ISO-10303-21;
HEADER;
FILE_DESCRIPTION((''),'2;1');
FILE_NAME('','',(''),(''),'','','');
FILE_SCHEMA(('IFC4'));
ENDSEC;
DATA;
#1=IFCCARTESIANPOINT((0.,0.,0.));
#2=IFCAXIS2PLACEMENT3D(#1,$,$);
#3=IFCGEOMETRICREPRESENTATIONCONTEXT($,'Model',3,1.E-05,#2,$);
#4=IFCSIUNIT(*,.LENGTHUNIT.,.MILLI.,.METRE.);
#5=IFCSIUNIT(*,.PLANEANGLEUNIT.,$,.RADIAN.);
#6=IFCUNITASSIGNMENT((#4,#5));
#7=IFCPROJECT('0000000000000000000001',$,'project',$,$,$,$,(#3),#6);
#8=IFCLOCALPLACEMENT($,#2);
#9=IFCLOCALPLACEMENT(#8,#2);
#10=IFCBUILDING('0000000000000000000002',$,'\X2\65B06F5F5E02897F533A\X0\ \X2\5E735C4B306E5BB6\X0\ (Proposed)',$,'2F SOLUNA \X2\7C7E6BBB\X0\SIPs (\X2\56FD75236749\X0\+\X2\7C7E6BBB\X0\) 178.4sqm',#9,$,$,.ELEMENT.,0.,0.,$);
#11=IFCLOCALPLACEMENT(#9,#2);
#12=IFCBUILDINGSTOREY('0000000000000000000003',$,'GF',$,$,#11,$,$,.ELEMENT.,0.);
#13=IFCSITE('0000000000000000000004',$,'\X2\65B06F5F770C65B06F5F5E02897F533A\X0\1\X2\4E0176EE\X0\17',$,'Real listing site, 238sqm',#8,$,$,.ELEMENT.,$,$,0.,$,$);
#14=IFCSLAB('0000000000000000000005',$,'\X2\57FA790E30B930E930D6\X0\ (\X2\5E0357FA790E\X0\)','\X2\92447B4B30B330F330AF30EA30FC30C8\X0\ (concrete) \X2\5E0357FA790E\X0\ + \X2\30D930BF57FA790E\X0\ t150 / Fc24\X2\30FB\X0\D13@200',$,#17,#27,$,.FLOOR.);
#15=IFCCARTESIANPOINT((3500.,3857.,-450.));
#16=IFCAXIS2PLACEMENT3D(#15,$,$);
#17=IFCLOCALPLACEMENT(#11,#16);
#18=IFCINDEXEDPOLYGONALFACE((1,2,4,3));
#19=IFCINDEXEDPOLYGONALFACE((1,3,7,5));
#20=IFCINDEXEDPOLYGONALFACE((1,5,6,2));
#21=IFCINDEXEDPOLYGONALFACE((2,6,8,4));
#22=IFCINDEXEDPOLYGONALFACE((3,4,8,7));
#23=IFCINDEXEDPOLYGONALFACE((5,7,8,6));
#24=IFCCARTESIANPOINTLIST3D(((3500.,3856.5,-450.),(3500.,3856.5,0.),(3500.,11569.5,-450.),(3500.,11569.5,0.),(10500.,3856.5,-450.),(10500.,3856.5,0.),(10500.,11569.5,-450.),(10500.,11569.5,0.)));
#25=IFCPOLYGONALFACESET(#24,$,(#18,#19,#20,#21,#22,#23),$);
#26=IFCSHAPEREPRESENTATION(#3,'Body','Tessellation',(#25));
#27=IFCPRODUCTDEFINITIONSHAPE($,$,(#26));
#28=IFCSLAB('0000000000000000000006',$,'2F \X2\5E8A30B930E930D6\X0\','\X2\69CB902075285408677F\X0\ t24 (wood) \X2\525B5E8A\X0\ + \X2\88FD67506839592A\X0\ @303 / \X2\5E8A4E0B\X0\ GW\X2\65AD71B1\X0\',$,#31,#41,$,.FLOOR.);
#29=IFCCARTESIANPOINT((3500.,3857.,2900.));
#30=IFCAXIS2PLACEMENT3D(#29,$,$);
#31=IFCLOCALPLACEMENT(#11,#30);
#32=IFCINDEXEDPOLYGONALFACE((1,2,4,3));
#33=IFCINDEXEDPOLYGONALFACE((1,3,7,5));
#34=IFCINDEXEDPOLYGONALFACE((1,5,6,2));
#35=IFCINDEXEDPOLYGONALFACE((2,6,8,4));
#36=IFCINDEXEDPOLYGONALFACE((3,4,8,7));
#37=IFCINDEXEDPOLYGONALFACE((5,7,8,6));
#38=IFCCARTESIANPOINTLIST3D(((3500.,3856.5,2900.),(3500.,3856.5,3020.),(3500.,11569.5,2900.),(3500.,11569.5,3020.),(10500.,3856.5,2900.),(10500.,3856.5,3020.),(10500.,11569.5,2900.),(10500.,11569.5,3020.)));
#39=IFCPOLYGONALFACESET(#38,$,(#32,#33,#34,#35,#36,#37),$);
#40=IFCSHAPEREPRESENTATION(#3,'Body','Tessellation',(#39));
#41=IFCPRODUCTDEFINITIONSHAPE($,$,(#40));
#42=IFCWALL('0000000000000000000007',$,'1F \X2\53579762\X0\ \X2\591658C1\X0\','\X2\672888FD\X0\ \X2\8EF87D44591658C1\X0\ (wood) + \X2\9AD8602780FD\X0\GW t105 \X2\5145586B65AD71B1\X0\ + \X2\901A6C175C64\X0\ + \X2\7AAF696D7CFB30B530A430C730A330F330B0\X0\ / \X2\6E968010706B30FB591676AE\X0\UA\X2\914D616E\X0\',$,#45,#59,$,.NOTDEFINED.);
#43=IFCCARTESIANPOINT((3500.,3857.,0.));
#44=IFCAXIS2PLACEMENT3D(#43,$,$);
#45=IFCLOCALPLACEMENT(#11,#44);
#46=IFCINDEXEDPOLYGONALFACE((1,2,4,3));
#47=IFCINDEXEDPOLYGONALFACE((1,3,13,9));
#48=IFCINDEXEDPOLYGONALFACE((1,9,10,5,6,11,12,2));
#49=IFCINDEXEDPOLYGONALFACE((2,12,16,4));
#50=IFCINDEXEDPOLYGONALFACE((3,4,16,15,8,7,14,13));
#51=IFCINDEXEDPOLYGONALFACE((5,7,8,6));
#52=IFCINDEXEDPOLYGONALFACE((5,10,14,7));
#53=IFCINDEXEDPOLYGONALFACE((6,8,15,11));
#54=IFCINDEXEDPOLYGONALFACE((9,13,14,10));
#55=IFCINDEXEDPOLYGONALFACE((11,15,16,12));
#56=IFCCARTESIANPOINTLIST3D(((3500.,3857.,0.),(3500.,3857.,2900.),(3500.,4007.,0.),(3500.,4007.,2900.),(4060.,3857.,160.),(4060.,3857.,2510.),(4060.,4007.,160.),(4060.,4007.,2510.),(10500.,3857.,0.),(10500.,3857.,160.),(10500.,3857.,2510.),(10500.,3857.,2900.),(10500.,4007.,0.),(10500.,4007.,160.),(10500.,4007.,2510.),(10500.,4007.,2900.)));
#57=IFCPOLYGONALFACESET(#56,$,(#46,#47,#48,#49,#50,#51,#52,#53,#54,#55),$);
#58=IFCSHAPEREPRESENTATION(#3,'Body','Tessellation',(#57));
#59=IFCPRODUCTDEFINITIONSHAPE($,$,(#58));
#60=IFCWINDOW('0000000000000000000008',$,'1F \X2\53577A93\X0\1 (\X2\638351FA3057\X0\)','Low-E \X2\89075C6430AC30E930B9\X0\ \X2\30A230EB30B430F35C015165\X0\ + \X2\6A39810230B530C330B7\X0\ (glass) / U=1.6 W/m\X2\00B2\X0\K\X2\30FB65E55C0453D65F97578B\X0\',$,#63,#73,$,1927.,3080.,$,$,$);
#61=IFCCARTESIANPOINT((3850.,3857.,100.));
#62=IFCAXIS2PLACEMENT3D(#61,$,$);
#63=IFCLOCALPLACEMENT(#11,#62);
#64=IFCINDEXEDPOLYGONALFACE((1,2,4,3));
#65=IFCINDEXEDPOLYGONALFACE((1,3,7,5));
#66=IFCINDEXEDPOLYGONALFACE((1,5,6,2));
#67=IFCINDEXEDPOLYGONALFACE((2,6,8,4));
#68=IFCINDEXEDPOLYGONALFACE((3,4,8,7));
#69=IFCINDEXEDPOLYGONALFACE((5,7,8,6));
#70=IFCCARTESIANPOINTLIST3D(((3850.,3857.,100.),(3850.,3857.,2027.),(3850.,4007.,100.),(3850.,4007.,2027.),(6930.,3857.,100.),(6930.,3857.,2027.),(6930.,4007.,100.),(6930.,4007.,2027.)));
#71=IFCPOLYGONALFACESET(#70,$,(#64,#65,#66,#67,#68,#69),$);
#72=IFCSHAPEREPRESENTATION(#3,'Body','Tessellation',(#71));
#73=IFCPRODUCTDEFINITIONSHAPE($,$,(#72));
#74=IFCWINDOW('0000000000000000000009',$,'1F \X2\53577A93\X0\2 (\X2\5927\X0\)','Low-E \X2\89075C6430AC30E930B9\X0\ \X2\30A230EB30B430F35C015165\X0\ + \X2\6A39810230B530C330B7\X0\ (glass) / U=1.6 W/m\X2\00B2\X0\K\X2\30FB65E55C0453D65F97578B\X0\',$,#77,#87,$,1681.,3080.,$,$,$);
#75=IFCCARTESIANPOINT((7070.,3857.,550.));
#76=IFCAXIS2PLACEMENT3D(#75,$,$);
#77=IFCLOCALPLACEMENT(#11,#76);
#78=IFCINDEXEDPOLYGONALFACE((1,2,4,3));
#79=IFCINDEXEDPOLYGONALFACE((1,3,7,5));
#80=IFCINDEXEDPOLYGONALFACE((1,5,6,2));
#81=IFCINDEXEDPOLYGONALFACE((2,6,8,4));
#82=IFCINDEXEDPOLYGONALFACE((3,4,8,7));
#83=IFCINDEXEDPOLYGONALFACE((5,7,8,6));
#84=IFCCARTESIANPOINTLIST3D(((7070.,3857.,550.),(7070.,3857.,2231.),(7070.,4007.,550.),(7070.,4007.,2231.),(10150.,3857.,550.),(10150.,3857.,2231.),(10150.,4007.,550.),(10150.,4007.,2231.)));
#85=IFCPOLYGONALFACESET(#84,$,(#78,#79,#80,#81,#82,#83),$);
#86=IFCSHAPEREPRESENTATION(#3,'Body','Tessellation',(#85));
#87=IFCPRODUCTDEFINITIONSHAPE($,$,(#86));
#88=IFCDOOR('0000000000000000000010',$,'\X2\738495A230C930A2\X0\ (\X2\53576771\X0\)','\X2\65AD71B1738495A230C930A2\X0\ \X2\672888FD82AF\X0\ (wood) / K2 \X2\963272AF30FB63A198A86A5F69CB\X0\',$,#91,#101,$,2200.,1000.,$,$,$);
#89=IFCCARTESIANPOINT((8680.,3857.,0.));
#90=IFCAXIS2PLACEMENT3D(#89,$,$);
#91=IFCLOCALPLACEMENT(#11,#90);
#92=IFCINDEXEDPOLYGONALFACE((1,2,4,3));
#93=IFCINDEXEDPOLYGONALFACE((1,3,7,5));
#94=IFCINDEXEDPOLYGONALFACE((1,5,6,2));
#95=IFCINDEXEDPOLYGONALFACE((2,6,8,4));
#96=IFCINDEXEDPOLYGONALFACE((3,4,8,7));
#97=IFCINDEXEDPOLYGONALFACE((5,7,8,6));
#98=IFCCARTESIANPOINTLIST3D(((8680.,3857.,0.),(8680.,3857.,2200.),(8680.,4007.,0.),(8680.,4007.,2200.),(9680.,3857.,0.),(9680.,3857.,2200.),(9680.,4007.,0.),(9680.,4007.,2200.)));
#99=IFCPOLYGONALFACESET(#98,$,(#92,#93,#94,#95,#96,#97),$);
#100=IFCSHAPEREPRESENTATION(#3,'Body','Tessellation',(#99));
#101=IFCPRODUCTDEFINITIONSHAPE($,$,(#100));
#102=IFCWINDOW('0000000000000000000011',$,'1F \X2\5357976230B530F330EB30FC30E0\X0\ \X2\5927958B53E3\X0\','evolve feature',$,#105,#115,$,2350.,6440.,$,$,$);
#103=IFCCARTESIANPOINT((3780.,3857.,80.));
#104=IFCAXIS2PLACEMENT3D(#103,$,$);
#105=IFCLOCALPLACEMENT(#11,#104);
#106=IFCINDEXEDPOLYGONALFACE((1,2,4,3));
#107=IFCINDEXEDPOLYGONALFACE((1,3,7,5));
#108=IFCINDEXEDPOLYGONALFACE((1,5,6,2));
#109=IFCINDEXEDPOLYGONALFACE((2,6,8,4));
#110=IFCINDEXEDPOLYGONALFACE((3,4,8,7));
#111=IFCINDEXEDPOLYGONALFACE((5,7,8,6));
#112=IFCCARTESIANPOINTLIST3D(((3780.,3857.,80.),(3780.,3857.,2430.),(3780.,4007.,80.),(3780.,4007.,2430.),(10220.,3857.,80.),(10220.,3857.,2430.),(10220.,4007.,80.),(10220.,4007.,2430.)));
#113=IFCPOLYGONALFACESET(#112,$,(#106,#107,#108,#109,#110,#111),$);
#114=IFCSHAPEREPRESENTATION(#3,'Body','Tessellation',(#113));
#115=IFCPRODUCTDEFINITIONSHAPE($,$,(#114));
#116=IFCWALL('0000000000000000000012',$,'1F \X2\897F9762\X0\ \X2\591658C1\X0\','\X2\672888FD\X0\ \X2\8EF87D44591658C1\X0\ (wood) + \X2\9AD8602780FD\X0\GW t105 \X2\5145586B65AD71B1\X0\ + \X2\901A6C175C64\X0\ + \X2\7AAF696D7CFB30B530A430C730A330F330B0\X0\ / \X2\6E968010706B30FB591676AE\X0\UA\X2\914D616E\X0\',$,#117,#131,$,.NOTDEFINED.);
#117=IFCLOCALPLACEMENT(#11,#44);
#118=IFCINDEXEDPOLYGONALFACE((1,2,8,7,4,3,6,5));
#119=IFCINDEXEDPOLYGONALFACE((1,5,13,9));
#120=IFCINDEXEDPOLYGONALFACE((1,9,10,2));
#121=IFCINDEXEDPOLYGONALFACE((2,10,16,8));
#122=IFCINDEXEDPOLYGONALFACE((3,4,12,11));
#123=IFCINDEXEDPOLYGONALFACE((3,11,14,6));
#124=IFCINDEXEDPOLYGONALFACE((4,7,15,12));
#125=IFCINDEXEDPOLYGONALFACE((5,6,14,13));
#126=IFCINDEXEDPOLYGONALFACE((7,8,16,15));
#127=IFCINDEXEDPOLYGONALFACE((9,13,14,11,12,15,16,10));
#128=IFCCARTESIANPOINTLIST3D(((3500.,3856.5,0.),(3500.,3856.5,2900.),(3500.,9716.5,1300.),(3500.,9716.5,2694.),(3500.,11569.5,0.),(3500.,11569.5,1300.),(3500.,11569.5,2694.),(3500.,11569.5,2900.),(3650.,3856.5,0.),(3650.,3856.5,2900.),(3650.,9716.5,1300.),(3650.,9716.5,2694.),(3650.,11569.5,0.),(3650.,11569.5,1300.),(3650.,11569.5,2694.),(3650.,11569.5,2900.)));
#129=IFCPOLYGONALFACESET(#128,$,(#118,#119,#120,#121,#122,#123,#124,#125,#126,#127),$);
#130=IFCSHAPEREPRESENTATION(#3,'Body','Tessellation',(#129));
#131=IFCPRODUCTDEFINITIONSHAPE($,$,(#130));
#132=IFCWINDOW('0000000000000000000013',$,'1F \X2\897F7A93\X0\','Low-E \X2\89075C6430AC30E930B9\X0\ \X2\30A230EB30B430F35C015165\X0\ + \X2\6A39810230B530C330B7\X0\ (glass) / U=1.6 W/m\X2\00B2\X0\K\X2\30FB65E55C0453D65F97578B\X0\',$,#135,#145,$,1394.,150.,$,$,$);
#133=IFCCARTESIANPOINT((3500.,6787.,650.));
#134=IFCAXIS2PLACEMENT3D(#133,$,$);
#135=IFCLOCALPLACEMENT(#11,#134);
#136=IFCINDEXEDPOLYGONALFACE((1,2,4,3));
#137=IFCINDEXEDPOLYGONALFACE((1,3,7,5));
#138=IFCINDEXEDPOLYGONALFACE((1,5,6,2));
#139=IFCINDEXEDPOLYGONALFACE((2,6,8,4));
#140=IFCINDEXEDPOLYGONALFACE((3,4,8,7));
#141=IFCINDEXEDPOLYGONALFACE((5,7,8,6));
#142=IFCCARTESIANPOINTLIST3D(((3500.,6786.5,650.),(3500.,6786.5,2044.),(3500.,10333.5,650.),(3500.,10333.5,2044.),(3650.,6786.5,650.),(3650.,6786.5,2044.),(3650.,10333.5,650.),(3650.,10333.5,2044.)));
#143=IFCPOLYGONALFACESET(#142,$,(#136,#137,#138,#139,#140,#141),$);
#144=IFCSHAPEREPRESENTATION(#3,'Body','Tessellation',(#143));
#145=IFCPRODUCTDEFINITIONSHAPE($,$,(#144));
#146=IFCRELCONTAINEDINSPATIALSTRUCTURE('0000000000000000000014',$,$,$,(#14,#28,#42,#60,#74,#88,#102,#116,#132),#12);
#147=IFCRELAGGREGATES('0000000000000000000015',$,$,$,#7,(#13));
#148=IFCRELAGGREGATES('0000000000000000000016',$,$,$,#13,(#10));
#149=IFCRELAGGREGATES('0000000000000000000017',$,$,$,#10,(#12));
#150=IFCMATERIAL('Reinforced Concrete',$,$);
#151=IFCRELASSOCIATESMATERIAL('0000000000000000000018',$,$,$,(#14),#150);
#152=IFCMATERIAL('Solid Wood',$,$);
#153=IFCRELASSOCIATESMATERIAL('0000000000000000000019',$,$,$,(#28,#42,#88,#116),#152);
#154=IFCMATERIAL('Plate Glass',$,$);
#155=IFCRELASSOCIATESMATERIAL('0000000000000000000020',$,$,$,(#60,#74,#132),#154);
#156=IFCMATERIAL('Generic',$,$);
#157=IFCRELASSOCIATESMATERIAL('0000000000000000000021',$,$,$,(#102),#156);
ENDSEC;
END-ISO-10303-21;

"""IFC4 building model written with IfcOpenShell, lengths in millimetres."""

from ifc_helpers import new_model, si_unit, frame, frame_2d, origin, place, context, project, spatial, rectangle, extrude, material, element, fill, save


model = new_model("IFC4")

# Units and contexts
model_context = context("Model", 3, precision=1e-05, world=origin())
ifc_project = project(units=[si_unit("LENGTHUNIT", "METRE", prefix="MILLI"), si_unit("PLANEANGLEUNIT", "RADIAN")], contexts=[model_context])

# Site, building, storey
site_placement = place(None, origin())
site = spatial("IfcSite", under=ifc_project, at=site_placement, Name="新潟県新潟市西区1丁目17", ObjectType="Real listing site, 238sqm", CompositionType="ELEMENT", RefElevation=0.0)
building_placement = place(site_placement, origin())
building = spatial("IfcBuilding", under=site, at=building_placement, Name="新潟市西区 平屋の家 (Proposed)", ObjectType="2F SOLUNA 籾殻SIPs (国産杉+籾殻) 178.4sqm", CompositionType="ELEMENT", ElevationOfRefHeight=0.0, ElevationOfTerrain=0.0)
storey_placement = place(building_placement, origin())
storey = spatial("IfcBuildingStorey", under=building, at=storey_placement, Name="GF", CompositionType="ELEMENT", Elevation=0.0)

# Slabs
ifc_material_1 = material(Name="Reinforced Concrete")
slab_1_placement = place(storey_placement, frame((3500.0, 3857.0, -450.0)))
element("IfcSlab", 1, at=slab_1_placement, inside=storey, material=ifc_material_1, Name="基礎スラブ (布基礎)", Description="鉄筋コンクリート (concrete) 布基礎 + ベタ基礎 t150 / Fc24・D13@200", PredefinedType="FLOOR", context=model_context, shape_type="SweptSolid", body=[
    extrude(rectangle(XDim=7000.0, YDim=7713.0, at=frame_2d((3500.0, 3856.0))), frame((3500.0, 3857.0, -450.0)), (0.0, 0.0, 1.0), 450.0),
])
ifc_material_2 = material(Name="Solid Wood")
slab_2_placement = place(storey_placement, frame((3500.0, 3857.0, 2900.0)))
element("IfcSlab", 2, at=slab_2_placement, inside=storey, material=ifc_material_2, Name="2F 床スラブ", Description="構造用合板 t24 (wood) 剛床 + 製材根太 @303 / 床下 GW断熱", PredefinedType="FLOOR", context=model_context, shape_type="SweptSolid", body=[
    extrude(rectangle(XDim=7000.0, YDim=7713.0, at=frame_2d((3500.0, 3856.0))), frame((3500.0, 3857.0, 2900.0)), (0.0, 0.0, 1.0), 120.0),
])
ifc_material_3 = material(Name="Generic")

# Wall, openings, windows, door
wall_1_placement = place(storey_placement, frame((3500.0, 3857.0, 0.0)))
wall_1 = element("IfcWall", 3, at=wall_1_placement, inside=storey, material=ifc_material_2, Name="1F 南面 外壁", Description="木製 軸組外壁 (wood) + 高性能GW t105 充填断熱 + 通気層 + 窯業系サイディング / 準耐火・外皮UA配慮", PredefinedType="NOTDEFINED", context=model_context, shape_type="SweptSolid", body=[
    extrude(rectangle(XDim=7000.0, YDim=150.0, at=frame_2d((3500.0, 75.0))), frame((3500.0, 3857.0, 0.0)), (0.0, 0.0, 1.0), 2900.0),
])
opening_1_placement = place(storey_placement, frame((3850.0, 3857.0, 100.0)))
opening_1 = element("IfcOpeningElement", 4, at=opening_1_placement, cuts=wall_1, PredefinedType="NOTDEFINED", context=model_context, shape_type="SweptSolid", body=[
    extrude(rectangle(XDim=3080.0, YDim=150.0, at=frame_2d((1540.0, 75.0))), frame((3850.0, 3857.0, 100.0)), (0.0, 0.0, 1.0), 1927.0),
])
opening_2_placement = place(storey_placement, frame((7070.0, 3857.0, 550.0)))
opening_2 = element("IfcOpeningElement", 5, at=opening_2_placement, cuts=wall_1, PredefinedType="NOTDEFINED", context=model_context, shape_type="SweptSolid", body=[
    extrude(rectangle(XDim=3080.0, YDim=150.0, at=frame_2d((1540.0, 75.0))), frame((7070.0, 3857.0, 550.0)), (0.0, 0.0, 1.0), 1681.0),
])
opening_3_placement = place(storey_placement, frame((8680.0, 3857.0, 0.0)))
opening_3 = element("IfcOpeningElement", 6, at=opening_3_placement, cuts=wall_1, PredefinedType="NOTDEFINED", context=model_context, shape_type="SweptSolid", body=[
    extrude(rectangle(XDim=1000.0, YDim=150.0, at=frame_2d((500.0, 75.0))), frame((8680.0, 3857.0, 0.0)), (0.0, 0.0, 1.0), 2200.0),
])
opening_4_placement = place(storey_placement, frame((3780.0, 3857.0, 80.0)))
opening_4 = element("IfcOpeningElement", 7, at=opening_4_placement, cuts=wall_1, PredefinedType="NOTDEFINED", context=model_context, shape_type="SweptSolid", body=[
    extrude(rectangle(XDim=6440.0, YDim=150.0, at=frame_2d((3220.0, 75.0))), frame((3780.0, 3857.0, 80.0)), (0.0, 0.0, 1.0), 2350.0),
])
ifc_material_4 = material(Name="Plate Glass")
window_1_placement = place(storey_placement, frame((3850.0, 3857.0, 100.0)))
window_1 = element("IfcWindow", 8, at=window_1_placement, inside=storey, material=ifc_material_4, Name="1F 南窓1 (掃出し)", Description="Low-E 複層ガラス アルゴン封入 + 樹脂サッシ (glass) / U=1.6 W/m²K・日射取得型", OverallHeight=1927.0, OverallWidth=3080.0, context=model_context, shape_type="SweptSolid", body=[
    extrude(rectangle(XDim=3080.0, YDim=150.0, at=frame_2d((1540.0, 75.0))), frame((3850.0, 3857.0, 100.0)), (0.0, 0.0, 1.0), 1927.0),
])
fill(opening_1, window_1)
window_2_placement = place(storey_placement, frame((7070.0, 3857.0, 550.0)))
window_2 = element("IfcWindow", 9, at=window_2_placement, inside=storey, material=ifc_material_4, Name="1F 南窓2 (大)", Description="Low-E 複層ガラス アルゴン封入 + 樹脂サッシ (glass) / U=1.6 W/m²K・日射取得型", OverallHeight=1681.0, OverallWidth=3080.0, context=model_context, shape_type="SweptSolid", body=[
    extrude(rectangle(XDim=3080.0, YDim=150.0, at=frame_2d((1540.0, 75.0))), frame((7070.0, 3857.0, 550.0)), (0.0, 0.0, 1.0), 1681.0),
])
fill(opening_2, window_2)
door_placement = place(storey_placement, frame((8680.0, 3857.0, 0.0)))
door = element("IfcDoor", 10, at=door_placement, inside=storey, material=ifc_material_2, Name="玄関ドア (南東)", Description="断熱玄関ドア 木製芯 (wood) / K2 防犯・採風機構", OverallHeight=2200.0, OverallWidth=1000.0, context=model_context, shape_type="SweptSolid", body=[
    extrude(rectangle(XDim=1000.0, YDim=150.0, at=frame_2d((500.0, 75.0))), frame((8680.0, 3857.0, 0.0)), (0.0, 0.0, 1.0), 2200.0),
])
fill(opening_3, door)
window_3_placement = place(storey_placement, frame((3780.0, 3857.0, 80.0)))
window_3 = element("IfcWindow", 11, at=window_3_placement, inside=storey, material=ifc_material_3, Name="1F 南面サンルーム 大開口", Description="evolve feature", OverallHeight=2350.0, OverallWidth=6440.0, context=model_context, shape_type="SweptSolid", body=[
    extrude(rectangle(XDim=6440.0, YDim=150.0, at=frame_2d((3220.0, 75.0))), frame((3780.0, 3857.0, 80.0)), (0.0, 0.0, 1.0), 2350.0),
])
fill(opening_4, window_3)

# Wall, opening, window
wall_2_placement = place(storey_placement, frame((3500.0, 3857.0, 0.0)))
wall_2 = element("IfcWall", 12, at=wall_2_placement, inside=storey, material=ifc_material_2, Name="1F 西面 外壁", Description="木製 軸組外壁 (wood) + 高性能GW t105 充填断熱 + 通気層 + 窯業系サイディング / 準耐火・外皮UA配慮", PredefinedType="NOTDEFINED", context=model_context, shape_type="SweptSolid", body=[
    extrude(rectangle(XDim=150.0, YDim=7713.0, at=frame_2d((75.0, 3856.0))), frame((3500.0, 3857.0, 0.0)), (0.0, 0.0, 1.0), 2900.0),
])
opening_5_placement = place(storey_placement, frame((3500.0, 6787.0, 650.0)))
opening_5 = element("IfcOpeningElement", 13, at=opening_5_placement, cuts=wall_2, PredefinedType="NOTDEFINED", context=model_context, shape_type="SweptSolid", body=[
    extrude(rectangle(XDim=150.0, YDim=3547.0, at=frame_2d((75.0, 1773.0))), frame((3500.0, 6787.0, 650.0)), (0.0, 0.0, 1.0), 1394.0),
])
window_4_placement = place(storey_placement, frame((3500.0, 6787.0, 650.0)))
window_4 = element("IfcWindow", 14, at=window_4_placement, inside=storey, material=ifc_material_4, Name="1F 西窓", Description="Low-E 複層ガラス アルゴン封入 + 樹脂サッシ (glass) / U=1.6 W/m²K・日射取得型", OverallHeight=1394.0, OverallWidth=150.0, context=model_context, shape_type="SweptSolid", body=[
    extrude(rectangle(XDim=150.0, YDim=3547.0, at=frame_2d((75.0, 1773.0))), frame((3500.0, 6787.0, 650.0)), (0.0, 0.0, 1.0), 1394.0),
])
fill(opening_5, window_4)

save(model, "model.ifc")
